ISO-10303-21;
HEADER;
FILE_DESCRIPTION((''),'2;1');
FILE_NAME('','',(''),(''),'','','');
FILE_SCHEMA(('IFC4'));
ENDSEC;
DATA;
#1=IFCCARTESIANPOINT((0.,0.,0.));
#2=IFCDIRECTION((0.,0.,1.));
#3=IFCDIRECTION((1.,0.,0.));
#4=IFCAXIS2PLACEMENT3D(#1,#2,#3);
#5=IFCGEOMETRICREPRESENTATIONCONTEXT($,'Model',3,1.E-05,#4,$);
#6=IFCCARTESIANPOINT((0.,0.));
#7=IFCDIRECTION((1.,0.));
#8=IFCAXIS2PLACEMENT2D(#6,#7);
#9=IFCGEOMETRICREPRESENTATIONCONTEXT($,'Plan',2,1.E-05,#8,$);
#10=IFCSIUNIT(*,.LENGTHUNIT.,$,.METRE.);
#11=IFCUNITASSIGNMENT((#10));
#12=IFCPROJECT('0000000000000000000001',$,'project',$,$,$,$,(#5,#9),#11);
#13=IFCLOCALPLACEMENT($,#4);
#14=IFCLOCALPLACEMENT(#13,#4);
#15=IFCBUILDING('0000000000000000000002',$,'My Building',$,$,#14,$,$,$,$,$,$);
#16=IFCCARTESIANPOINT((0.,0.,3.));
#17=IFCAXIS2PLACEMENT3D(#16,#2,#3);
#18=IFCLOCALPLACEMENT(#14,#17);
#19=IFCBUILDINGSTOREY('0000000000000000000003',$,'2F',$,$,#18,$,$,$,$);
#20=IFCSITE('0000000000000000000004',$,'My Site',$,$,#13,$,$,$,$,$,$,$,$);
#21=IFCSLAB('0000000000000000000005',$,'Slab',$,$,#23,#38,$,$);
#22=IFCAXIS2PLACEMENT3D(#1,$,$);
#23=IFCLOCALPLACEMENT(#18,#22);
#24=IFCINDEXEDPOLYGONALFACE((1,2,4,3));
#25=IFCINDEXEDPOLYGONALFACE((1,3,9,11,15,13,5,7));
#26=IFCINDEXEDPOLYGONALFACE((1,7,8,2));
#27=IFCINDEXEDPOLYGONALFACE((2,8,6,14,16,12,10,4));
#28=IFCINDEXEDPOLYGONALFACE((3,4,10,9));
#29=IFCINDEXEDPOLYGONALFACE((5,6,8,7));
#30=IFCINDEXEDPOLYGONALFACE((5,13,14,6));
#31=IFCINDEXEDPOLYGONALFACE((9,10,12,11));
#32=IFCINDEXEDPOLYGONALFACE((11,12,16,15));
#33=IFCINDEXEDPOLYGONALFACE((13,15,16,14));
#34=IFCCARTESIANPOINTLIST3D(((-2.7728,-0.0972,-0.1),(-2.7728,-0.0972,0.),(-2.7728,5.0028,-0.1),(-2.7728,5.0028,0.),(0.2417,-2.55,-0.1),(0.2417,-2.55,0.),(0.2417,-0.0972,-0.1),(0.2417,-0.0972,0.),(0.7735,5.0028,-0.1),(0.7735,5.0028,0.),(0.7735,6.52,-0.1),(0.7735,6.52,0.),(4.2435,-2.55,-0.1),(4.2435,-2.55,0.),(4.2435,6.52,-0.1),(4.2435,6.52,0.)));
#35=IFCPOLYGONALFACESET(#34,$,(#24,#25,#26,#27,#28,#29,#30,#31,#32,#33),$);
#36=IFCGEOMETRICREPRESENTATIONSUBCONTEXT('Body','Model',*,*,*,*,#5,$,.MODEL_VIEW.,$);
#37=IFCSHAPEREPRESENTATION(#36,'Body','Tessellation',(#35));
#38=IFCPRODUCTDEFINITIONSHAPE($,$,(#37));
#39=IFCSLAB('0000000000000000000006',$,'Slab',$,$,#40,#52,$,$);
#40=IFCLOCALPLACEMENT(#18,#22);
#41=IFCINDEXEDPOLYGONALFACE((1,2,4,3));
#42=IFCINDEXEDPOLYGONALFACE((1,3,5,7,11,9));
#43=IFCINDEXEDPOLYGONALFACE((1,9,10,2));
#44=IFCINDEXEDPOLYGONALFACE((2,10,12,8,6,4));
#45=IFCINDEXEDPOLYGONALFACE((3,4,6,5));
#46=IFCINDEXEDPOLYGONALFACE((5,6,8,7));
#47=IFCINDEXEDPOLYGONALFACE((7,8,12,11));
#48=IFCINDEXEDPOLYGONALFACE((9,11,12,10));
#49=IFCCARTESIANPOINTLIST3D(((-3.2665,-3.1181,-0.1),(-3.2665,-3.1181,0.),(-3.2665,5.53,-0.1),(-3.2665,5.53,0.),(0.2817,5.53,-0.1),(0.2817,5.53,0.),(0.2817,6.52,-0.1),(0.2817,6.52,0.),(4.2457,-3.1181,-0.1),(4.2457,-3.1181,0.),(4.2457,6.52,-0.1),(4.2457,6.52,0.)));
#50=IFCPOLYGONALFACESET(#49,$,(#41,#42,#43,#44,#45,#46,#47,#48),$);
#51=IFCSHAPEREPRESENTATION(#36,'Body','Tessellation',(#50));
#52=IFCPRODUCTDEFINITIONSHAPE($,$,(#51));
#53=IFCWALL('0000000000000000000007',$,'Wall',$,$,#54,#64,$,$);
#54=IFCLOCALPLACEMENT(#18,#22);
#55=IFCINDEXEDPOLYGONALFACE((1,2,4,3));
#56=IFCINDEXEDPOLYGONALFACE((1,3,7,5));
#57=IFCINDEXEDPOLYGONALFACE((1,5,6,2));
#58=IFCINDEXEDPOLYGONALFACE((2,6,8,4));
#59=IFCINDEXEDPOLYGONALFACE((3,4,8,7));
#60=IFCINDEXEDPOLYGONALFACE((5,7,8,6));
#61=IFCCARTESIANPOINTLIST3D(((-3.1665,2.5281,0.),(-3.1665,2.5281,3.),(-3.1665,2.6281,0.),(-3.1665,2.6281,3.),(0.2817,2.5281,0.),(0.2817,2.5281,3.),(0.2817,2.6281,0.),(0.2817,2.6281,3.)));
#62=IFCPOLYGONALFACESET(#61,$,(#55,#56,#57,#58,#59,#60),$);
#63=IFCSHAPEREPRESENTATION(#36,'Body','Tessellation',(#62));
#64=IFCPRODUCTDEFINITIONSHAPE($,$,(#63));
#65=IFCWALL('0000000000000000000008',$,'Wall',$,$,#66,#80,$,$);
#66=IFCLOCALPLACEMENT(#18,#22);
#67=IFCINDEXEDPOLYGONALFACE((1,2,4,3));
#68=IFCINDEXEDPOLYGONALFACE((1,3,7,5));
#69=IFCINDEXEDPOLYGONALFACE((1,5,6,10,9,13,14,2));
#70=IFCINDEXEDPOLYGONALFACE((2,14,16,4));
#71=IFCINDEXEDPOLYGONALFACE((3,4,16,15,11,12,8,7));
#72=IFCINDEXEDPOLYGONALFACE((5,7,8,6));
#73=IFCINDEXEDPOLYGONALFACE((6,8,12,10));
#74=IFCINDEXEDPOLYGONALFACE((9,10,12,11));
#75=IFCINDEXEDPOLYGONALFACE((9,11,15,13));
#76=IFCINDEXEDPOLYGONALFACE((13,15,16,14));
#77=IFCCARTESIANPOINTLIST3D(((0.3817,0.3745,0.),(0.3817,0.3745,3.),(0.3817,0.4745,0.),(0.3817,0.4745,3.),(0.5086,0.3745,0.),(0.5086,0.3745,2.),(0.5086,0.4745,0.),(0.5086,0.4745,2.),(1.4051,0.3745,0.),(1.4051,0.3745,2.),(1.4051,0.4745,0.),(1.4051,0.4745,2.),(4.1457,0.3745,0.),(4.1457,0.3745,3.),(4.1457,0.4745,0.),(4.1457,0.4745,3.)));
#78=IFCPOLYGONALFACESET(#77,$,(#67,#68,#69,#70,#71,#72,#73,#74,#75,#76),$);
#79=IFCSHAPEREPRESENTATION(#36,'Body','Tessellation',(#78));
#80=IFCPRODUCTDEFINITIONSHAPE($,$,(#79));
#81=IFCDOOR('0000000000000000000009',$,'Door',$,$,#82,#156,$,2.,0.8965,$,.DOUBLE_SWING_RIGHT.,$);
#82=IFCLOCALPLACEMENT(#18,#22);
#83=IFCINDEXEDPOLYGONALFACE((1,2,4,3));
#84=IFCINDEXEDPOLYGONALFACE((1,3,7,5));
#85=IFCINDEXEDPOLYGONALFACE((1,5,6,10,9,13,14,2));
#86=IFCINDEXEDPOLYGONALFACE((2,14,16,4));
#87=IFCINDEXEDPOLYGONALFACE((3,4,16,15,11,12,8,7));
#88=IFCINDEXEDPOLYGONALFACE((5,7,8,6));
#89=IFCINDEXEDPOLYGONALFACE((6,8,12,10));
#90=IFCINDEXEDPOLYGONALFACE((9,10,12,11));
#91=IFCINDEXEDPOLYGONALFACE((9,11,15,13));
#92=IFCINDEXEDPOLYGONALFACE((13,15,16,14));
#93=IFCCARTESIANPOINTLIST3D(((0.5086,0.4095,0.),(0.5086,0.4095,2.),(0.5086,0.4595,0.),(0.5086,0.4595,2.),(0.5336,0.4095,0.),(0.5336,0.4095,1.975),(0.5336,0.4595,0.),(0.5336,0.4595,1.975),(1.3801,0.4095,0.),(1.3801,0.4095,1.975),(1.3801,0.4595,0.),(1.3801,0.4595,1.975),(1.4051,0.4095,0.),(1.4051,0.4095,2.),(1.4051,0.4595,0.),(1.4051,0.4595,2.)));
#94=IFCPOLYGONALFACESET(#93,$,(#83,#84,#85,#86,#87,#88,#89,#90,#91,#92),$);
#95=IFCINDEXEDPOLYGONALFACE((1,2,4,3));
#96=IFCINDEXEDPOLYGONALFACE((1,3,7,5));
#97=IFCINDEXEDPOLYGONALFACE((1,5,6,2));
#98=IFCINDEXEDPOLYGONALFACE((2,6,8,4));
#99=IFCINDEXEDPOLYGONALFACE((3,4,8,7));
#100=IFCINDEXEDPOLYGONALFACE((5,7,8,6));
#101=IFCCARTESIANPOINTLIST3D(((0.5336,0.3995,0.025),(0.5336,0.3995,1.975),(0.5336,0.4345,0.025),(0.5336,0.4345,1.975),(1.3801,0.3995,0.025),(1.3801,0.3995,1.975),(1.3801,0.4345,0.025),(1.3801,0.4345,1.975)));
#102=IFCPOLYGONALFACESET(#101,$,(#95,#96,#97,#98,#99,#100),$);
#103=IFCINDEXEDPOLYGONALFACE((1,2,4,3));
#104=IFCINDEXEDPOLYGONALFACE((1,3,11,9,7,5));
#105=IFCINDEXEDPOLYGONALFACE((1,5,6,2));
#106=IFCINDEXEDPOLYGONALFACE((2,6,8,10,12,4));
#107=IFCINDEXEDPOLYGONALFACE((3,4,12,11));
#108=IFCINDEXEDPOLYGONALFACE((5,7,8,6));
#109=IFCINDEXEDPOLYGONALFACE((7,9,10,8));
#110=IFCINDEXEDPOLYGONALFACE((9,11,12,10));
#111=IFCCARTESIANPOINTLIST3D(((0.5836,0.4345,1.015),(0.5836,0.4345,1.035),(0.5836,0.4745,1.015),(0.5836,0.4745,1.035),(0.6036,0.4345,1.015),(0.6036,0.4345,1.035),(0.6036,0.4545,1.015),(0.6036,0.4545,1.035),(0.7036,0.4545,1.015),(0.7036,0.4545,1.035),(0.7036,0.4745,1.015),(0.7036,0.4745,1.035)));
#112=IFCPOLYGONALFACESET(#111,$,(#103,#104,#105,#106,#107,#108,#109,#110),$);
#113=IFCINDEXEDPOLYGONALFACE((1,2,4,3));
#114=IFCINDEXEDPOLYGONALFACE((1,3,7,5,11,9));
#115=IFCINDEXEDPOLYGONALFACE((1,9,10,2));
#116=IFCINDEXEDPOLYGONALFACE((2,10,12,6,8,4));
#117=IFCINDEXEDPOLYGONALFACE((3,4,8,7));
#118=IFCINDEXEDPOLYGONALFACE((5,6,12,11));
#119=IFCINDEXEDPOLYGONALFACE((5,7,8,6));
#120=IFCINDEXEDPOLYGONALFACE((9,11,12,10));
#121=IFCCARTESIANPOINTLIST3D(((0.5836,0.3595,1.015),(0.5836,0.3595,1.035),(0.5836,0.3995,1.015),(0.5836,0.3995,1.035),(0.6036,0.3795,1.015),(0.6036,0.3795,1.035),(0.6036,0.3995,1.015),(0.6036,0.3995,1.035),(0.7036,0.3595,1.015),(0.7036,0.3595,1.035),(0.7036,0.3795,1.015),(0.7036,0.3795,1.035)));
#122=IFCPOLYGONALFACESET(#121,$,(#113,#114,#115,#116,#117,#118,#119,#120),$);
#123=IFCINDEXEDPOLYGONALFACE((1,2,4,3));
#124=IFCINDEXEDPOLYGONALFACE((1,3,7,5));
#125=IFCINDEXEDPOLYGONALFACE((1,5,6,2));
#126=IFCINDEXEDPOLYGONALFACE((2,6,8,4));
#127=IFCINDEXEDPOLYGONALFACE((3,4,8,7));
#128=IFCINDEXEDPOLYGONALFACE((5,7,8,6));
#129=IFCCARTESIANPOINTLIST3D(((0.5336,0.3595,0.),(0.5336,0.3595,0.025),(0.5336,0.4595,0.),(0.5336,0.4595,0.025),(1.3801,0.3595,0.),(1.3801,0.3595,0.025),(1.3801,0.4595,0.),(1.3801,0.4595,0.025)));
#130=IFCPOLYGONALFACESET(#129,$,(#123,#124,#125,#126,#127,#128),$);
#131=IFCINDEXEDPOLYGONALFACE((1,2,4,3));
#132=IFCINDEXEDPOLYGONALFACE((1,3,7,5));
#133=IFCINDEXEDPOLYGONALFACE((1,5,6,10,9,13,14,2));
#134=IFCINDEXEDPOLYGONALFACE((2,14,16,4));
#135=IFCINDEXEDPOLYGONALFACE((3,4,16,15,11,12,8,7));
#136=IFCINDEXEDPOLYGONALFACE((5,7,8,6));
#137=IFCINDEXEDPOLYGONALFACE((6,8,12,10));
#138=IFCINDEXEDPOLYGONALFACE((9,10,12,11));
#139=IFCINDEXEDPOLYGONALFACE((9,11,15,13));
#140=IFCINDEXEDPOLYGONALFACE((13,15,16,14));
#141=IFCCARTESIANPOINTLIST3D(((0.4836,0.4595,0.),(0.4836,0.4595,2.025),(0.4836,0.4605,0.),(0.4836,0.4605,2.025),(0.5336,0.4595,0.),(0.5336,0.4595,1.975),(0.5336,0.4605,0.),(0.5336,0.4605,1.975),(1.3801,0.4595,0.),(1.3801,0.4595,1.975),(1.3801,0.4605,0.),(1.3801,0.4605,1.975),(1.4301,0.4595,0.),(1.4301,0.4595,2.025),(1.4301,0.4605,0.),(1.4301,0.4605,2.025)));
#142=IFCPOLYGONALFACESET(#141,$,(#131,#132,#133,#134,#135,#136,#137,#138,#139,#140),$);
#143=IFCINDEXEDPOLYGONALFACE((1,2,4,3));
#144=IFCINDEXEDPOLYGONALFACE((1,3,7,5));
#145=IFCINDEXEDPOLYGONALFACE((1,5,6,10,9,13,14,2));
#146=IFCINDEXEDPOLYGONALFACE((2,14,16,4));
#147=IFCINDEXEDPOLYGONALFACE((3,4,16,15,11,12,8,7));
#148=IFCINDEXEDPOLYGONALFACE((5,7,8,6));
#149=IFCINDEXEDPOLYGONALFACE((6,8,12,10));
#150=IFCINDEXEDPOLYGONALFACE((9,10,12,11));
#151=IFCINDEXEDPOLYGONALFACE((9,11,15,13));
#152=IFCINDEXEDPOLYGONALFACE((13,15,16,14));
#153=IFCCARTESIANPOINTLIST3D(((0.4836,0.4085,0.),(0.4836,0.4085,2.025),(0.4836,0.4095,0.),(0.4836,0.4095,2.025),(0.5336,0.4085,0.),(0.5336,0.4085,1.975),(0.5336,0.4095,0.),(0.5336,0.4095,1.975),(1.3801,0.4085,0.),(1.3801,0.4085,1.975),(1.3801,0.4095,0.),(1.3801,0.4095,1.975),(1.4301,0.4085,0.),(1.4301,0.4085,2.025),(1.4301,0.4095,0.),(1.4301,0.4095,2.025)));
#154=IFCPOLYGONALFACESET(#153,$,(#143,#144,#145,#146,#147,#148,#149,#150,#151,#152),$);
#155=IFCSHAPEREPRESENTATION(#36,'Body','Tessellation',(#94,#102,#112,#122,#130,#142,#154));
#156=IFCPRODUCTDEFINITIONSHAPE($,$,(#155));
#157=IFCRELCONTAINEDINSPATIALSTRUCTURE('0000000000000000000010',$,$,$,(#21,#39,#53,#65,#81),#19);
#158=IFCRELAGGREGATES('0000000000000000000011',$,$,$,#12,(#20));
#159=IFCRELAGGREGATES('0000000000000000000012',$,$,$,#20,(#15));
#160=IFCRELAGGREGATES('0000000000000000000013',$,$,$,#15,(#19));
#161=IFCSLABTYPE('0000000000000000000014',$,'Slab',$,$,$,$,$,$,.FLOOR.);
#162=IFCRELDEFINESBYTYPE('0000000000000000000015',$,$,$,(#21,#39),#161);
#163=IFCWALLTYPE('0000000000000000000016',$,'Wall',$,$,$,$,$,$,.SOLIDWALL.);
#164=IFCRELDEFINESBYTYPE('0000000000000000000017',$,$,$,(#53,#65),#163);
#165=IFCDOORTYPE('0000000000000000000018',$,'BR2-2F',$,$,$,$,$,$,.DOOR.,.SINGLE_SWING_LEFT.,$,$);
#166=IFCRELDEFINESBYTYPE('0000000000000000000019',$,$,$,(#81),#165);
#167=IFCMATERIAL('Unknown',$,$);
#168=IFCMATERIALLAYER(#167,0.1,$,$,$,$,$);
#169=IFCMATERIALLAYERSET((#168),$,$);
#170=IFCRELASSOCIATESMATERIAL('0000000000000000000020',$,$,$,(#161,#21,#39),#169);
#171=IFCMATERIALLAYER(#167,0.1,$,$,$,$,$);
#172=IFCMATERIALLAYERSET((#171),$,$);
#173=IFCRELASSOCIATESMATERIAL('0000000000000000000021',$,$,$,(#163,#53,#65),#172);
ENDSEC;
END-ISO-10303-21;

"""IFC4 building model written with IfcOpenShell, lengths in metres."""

from ifc_helpers import new_model, entity, si_unit, frame, origin_with_axes, origin_2d_with_axis, place, context, subcontext, project, spatial, line, indexed_curve, outline, extrude, shape, source, transform, mapped, material, layer, layer_set, layer_usage, type_object, type_shapes, element, fill, save


model = new_model("IFC4")

# Units and contexts
model_context = context("Model", 3, precision=1e-05, world=origin_with_axes())
plan_context = context("Plan", 2, precision=1e-05, world=origin_2d_with_axis())
body_context_1 = subcontext(model_context, "Body", "Model", "MODEL_VIEW")
body_context_2 = subcontext(plan_context, "Body", "Plan", "PLAN_VIEW")
ifc_project = project(units=[si_unit("LENGTHUNIT", "METRE")], contexts=[model_context, plan_context])

# Site, building, storey
site_placement = place(None, origin_with_axes())
site = spatial("IfcSite", under=ifc_project, at=site_placement, Name="My Site")
building_placement = place(site_placement, origin_with_axes())
building = spatial("IfcBuilding", under=site, at=building_placement, Name="My Building")
storey_placement = place(building_placement, frame((0.0, 0.0, 3.0), z_axis=(0.0, 0.0, 1.0), x_axis=(1.0, 0.0, 0.0)))
storey = spatial("IfcBuildingStorey", under=building, at=storey_placement, Name="2F")

# Slabs
ifc_material = material(Name="Unknown")
ifc_layer_1 = layer(ifc_material, 0.1)
ifc_layer_set_1 = layer_set([ifc_layer_1])
ifc_layer_usage_1 = layer_usage(ifc_layer_set_1, "AXIS3", "POSITIVE", -0.1)
slab_type = type_object("IfcSlabType", Name="Slab", PredefinedType="FLOOR", material=ifc_layer_set_1)
slab_1_placement = place(storey_placement, frame((4.2435, -2.55, 0.0), z_axis=(0.0, 0.0, 1.0), x_axis=(1.0, 0.0, 0.0)))
element("IfcSlab", 1, at=slab_1_placement, inside=storey, type_object=slab_type, material=ifc_layer_usage_1, Name="Slab", context=body_context_1, shape_type="SweptSolid", body=[
    extrude(outline(indexed_curve([(0.0, 0.0), (0.0, 9.07), (-3.47, 9.07), (-3.47, 7.5528), (-7.0163, 7.5528), (-7.0163, 2.4528), (-4.0018, 2.4528), (-4.0018, 0.0), (0.0, 0.0)])), frame((0.0, 0.0, -0.1), z_axis=(0.0, 0.0, 1.0), x_axis=(1.0, 0.0, 0.0)), (0.0, 0.0, 1.0), 0.1),
])
ifc_layer_usage_2 = layer_usage(ifc_layer_set_1, "AXIS3", "POSITIVE", -0.1)
slab_2_placement = place(storey_placement, frame((4.2457, -3.1181, 0.0), z_axis=(0.0, 0.0, 1.0), x_axis=(1.0, 0.0, 0.0)))
element("IfcSlab", 2, at=slab_2_placement, inside=storey, type_object=slab_type, material=ifc_layer_usage_2, Name="Slab", context=body_context_1, shape_type="SweptSolid", body=[
    extrude(outline(indexed_curve([(0.0, 0.0), (0.0, 9.6381), (-3.964, 9.6381), (-3.964, 8.6481), (-7.5122, 8.6481), (-7.5122, 0.0), (0.0, 0.0)])), frame((0.0, 0.0, -0.1), z_axis=(0.0, 0.0, 1.0), x_axis=(1.0, 0.0, 0.0)), (0.0, 0.0, 1.0), 0.1),
])

# Wall
ifc_layer_2 = layer(ifc_material, 0.1)
ifc_layer_set_2 = layer_set([ifc_layer_2])
ifc_layer_usage_3 = layer_usage(ifc_layer_set_2, "AXIS2", "POSITIVE", 0.0)
wall_type_1 = type_object("IfcWallType", Name="Wall", PredefinedType="SOLIDWALL", material=ifc_layer_set_2)
wall_1_placement = place(storey_placement, frame((0.2817, 2.6281, 0.0), z_axis=(0.0, 0.0, 1.0), x_axis=(-1.0, 0.0, 0.0)))
element("IfcWall", 3, at=wall_1_placement, inside=storey, type_object=wall_type_1, material=ifc_layer_usage_3, Name="Wall", context=body_context_1, shape_type="SweptSolid", body=[
    extrude(outline(indexed_curve([(0.0, 0.0), (0.0, 0.1), (3.4482, 0.1), (3.4482, 0.0)], segments=[line(1, 2, 3, 4, 1)])), origin_with_axes(), (0.0, 0.0, 1.0), 3.0),
])

# Wall, opening, door
ifc_layer_usage_4 = layer_usage(ifc_layer_set_2, "AXIS2", "POSITIVE", 0.0)
wall_2_placement = place(storey_placement, frame((4.1457, 0.4745, 0.0), z_axis=(0.0, 0.0, 1.0), x_axis=(-1.0, 0.0, 0.0)))
wall_2 = element("IfcWall", 4, at=wall_2_placement, inside=storey, type_object=wall_type_1, material=ifc_layer_usage_4, Name="Wall", context=body_context_1, shape_type="SweptSolid", body=[
    extrude(outline(indexed_curve([(0.0, 0.0), (0.0, 0.1), (3.764, 0.1), (3.764, 0.0)], segments=[line(1, 2, 3, 4, 1)])), origin_with_axes(), (0.0, 0.0, 1.0), 3.0),
])
shared_shape_1 = source(origin_with_axes(), body_context_1, "Body", "SweptSolid", [
    extrude(outline(indexed_curve([(0.0, 0.0), (0.8965, 0.0), (0.8965, 2.0), (0.0, 2.0)], segments=[line(1, 2, 3, 4, 1)])), frame((0.0, -0.6, 0.0), z_axis=(0.0, -1.0, 0.0), x_axis=(1.0, 0.0, 0.0)), (0.0, 0.0, -1.0), 1.2),
])
opening_1_placement = place(wall_2_placement, frame((2.7406, 0.015, 0.0), z_axis=(0.0, 0.0, 1.0), x_axis=(1.0, 0.0, 0.0)))
opening_1 = element("IfcOpeningElement", 5, at=opening_1_placement, cuts=wall_2, PredefinedType="OPENING", context=body_context_1, shape_type="MappedRepresentation", body=[
    mapped(shared_shape_1, transform((0.0, 0.0, 0.0), x_axis=(1.0, 0.0, 0.0), y_axis=(0.0, 1.0, 0.0), z_axis=(0.0, 0.0, 1.0), scale=1.0)),
])
door_type_1 = type_object("IfcDoorType", Name="BR2-2F", OperationType="SINGLE_SWING_LEFT", PredefinedType="DOOR")
shared_shape_2 = source(origin_with_axes(), body_context_1, "Body", "SweptSolid", [
    extrude(outline(indexed_curve([(0.0, 0.0), (0.0, 2.0), (0.8965, 2.0), (0.8965, 0.0), (0.8715, 0.0), (0.8715, 1.975), (0.025, 1.975), (0.025, 0.0)], segments=[line(1, 2, 3, 4, 5, 6, 7, 8, 1)])), frame((0.0, 0.0, 0.0), z_axis=(0.0, -1.0, 0.0), x_axis=(1.0, 0.0, 0.0)), (0.0, 0.0, -1.0), 0.05),
    extrude(outline(indexed_curve([(0.0, 0.0), (0.8465, 0.0), (0.8465, 0.035), (0.0, 0.035)], segments=[line(1, 2, 3, 4, 1)])), frame((0.025, 0.025, 0.025), z_axis=(0.0, 0.0, 1.0), x_axis=(1.0, 0.0, 0.0)), (0.0, 0.0, 1.0), 1.95),
    extrude(outline(indexed_curve([(0.0, 0.0), (0.0, -0.04), (-0.12, -0.04), (-0.12, -0.02), (-0.02, -0.02), (-0.02, 0.0)], segments=[line(1, 2, 3, 4, 5, 6, 1)])), frame((0.8215, 0.025, 1.015), z_axis=(0.0, 0.0, 1.0), x_axis=(1.0, 0.0, 0.0)), (0.0, 0.0, 1.0), 0.02),
    extrude(outline(indexed_curve([(0.0, 0.0), (0.0, 0.04), (-0.12, 0.04), (-0.12, 0.02), (-0.02, 0.02), (-0.02, 0.0)], segments=[line(1, 2, 3, 4, 5, 6, 1)])), frame((0.8215, 0.06, 1.015), z_axis=(0.0, 0.0, 1.0), x_axis=(1.0, 0.0, 0.0)), (0.0, 0.0, 1.0), 0.02),
    extrude(outline(indexed_curve([(0.0, 0.0), (0.8465, 0.0), (0.8465, 0.1), (0.0, 0.1)], segments=[line(1, 2, 3, 4, 1)])), frame((0.025, 0.0, 0.0), z_axis=(0.0, 0.0, 1.0), x_axis=(1.0, 0.0, 0.0)), (0.0, 0.0, 1.0), 0.025),
    extrude(outline(indexed_curve([(0.0, 0.0), (0.0, 2.025), (0.9465, 2.025), (0.9465, 0.0), (0.8965, 0.0), (0.8965, 1.975), (0.05, 1.975), (0.05, 0.0)], segments=[line(1, 2, 3, 4, 5, 6, 7, 8, 1)])), frame((-0.025, -0.001, 0.0), z_axis=(0.0, -1.0, 0.0), x_axis=(1.0, 0.0, 0.0)), (0.0, 0.0, -1.0), 0.001),
    extrude(outline(indexed_curve([(0.0, 0.0), (0.0, 2.025), (0.9465, 2.025), (0.9465, 0.0), (0.8965, 0.0), (0.8965, 1.975), (0.05, 1.975), (0.05, 0.0)], segments=[line(1, 2, 3, 4, 5, 6, 7, 8, 1)])), frame((-0.025, 0.05, 0.0), z_axis=(0.0, -1.0, 0.0), x_axis=(1.0, 0.0, 0.0)), (0.0, 0.0, -1.0), 0.001),
])
shared_shape_3 = source(origin_with_axes(), body_context_2, "Body", "Curve2D", [
    entity("IfcIndexedPolyCurve", entity("IfcCartesianPointList2D", [[0.0, 0.0], [0.025, 0.0], [0.025, 0.05], [0.0, 0.05]]), [entity("IfcLineIndex", [1, 2, 3, 4, 1])]),
    entity("IfcIndexedPolyCurve", entity("IfcCartesianPointList2D", [[0.8965, 0.0], [0.8715, 0.0], [0.8715, 0.05], [0.8965, 0.05]]), [entity("IfcLineIndex", [1, 2, 3, 4, 1])]),
    entity("IfcIndexedPolyCurve", entity("IfcCartesianPointList2D", [[0.025, 0.05], [0.025, -0.7965], [0.06, -0.7965]])),
    entity("IfcTrimmedCurve", entity("IfcEllipse", entity("IfcAxis2Placement2D", entity("IfcCartesianPoint", [0.06, 0.05]), entity("IfcDirection", [1.0, 0.0])), 0.8115, 0.8465), [entity("IfcCartesianPoint", [0.06, -0.7965])], [entity("IfcCartesianPoint", [0.06, 0.8965])], True, "CARTESIAN"),
    entity("IfcIndexedPolyCurve", entity("IfcCartesianPointList2D", [[0.025, 0.05], [0.06, 0.05], [0.06, 0.8965], [0.025, 0.8965]]), [entity("IfcLineIndex", [1, 2, 3, 4, 1])]),
])
type_shapes(door_type_1, [shared_shape_2, shared_shape_3])
door_1_placement = place(opening_1_placement, frame((0.0, 0.0, 0.0), z_axis=(0.0, 0.0, 1.0), x_axis=(1.0, 0.0, 0.0)))
door_1 = element("IfcDoor", 6, at=door_1_placement, inside=storey, type_object=door_type_1, Name="Door", OperationType="DOUBLE_SWING_RIGHT", OverallHeight=2.0, OverallWidth=0.8965, shapes=[
    shape(body_context_1, "Body", "MappedRepresentation", [mapped(shared_shape_2, transform((0.0, 0.0, 0.0), x_axis=(1.0, 0.0, 0.0), y_axis=(0.0, 1.0, 0.0), z_axis=(0.0, 0.0, 1.0), scale=1.0))]),
    shape(body_context_2, "Body", "MappedRepresentation", [mapped(shared_shape_3, transform((0.0, 0.0, 0.0), x_axis=(1.0, 0.0, 0.0), y_axis=(0.0, 1.0, 0.0), z_axis=(0.0, 0.0, 1.0), scale=1.0))]),
])
fill(opening_1, door_1)

save(model, "model.ifc")
